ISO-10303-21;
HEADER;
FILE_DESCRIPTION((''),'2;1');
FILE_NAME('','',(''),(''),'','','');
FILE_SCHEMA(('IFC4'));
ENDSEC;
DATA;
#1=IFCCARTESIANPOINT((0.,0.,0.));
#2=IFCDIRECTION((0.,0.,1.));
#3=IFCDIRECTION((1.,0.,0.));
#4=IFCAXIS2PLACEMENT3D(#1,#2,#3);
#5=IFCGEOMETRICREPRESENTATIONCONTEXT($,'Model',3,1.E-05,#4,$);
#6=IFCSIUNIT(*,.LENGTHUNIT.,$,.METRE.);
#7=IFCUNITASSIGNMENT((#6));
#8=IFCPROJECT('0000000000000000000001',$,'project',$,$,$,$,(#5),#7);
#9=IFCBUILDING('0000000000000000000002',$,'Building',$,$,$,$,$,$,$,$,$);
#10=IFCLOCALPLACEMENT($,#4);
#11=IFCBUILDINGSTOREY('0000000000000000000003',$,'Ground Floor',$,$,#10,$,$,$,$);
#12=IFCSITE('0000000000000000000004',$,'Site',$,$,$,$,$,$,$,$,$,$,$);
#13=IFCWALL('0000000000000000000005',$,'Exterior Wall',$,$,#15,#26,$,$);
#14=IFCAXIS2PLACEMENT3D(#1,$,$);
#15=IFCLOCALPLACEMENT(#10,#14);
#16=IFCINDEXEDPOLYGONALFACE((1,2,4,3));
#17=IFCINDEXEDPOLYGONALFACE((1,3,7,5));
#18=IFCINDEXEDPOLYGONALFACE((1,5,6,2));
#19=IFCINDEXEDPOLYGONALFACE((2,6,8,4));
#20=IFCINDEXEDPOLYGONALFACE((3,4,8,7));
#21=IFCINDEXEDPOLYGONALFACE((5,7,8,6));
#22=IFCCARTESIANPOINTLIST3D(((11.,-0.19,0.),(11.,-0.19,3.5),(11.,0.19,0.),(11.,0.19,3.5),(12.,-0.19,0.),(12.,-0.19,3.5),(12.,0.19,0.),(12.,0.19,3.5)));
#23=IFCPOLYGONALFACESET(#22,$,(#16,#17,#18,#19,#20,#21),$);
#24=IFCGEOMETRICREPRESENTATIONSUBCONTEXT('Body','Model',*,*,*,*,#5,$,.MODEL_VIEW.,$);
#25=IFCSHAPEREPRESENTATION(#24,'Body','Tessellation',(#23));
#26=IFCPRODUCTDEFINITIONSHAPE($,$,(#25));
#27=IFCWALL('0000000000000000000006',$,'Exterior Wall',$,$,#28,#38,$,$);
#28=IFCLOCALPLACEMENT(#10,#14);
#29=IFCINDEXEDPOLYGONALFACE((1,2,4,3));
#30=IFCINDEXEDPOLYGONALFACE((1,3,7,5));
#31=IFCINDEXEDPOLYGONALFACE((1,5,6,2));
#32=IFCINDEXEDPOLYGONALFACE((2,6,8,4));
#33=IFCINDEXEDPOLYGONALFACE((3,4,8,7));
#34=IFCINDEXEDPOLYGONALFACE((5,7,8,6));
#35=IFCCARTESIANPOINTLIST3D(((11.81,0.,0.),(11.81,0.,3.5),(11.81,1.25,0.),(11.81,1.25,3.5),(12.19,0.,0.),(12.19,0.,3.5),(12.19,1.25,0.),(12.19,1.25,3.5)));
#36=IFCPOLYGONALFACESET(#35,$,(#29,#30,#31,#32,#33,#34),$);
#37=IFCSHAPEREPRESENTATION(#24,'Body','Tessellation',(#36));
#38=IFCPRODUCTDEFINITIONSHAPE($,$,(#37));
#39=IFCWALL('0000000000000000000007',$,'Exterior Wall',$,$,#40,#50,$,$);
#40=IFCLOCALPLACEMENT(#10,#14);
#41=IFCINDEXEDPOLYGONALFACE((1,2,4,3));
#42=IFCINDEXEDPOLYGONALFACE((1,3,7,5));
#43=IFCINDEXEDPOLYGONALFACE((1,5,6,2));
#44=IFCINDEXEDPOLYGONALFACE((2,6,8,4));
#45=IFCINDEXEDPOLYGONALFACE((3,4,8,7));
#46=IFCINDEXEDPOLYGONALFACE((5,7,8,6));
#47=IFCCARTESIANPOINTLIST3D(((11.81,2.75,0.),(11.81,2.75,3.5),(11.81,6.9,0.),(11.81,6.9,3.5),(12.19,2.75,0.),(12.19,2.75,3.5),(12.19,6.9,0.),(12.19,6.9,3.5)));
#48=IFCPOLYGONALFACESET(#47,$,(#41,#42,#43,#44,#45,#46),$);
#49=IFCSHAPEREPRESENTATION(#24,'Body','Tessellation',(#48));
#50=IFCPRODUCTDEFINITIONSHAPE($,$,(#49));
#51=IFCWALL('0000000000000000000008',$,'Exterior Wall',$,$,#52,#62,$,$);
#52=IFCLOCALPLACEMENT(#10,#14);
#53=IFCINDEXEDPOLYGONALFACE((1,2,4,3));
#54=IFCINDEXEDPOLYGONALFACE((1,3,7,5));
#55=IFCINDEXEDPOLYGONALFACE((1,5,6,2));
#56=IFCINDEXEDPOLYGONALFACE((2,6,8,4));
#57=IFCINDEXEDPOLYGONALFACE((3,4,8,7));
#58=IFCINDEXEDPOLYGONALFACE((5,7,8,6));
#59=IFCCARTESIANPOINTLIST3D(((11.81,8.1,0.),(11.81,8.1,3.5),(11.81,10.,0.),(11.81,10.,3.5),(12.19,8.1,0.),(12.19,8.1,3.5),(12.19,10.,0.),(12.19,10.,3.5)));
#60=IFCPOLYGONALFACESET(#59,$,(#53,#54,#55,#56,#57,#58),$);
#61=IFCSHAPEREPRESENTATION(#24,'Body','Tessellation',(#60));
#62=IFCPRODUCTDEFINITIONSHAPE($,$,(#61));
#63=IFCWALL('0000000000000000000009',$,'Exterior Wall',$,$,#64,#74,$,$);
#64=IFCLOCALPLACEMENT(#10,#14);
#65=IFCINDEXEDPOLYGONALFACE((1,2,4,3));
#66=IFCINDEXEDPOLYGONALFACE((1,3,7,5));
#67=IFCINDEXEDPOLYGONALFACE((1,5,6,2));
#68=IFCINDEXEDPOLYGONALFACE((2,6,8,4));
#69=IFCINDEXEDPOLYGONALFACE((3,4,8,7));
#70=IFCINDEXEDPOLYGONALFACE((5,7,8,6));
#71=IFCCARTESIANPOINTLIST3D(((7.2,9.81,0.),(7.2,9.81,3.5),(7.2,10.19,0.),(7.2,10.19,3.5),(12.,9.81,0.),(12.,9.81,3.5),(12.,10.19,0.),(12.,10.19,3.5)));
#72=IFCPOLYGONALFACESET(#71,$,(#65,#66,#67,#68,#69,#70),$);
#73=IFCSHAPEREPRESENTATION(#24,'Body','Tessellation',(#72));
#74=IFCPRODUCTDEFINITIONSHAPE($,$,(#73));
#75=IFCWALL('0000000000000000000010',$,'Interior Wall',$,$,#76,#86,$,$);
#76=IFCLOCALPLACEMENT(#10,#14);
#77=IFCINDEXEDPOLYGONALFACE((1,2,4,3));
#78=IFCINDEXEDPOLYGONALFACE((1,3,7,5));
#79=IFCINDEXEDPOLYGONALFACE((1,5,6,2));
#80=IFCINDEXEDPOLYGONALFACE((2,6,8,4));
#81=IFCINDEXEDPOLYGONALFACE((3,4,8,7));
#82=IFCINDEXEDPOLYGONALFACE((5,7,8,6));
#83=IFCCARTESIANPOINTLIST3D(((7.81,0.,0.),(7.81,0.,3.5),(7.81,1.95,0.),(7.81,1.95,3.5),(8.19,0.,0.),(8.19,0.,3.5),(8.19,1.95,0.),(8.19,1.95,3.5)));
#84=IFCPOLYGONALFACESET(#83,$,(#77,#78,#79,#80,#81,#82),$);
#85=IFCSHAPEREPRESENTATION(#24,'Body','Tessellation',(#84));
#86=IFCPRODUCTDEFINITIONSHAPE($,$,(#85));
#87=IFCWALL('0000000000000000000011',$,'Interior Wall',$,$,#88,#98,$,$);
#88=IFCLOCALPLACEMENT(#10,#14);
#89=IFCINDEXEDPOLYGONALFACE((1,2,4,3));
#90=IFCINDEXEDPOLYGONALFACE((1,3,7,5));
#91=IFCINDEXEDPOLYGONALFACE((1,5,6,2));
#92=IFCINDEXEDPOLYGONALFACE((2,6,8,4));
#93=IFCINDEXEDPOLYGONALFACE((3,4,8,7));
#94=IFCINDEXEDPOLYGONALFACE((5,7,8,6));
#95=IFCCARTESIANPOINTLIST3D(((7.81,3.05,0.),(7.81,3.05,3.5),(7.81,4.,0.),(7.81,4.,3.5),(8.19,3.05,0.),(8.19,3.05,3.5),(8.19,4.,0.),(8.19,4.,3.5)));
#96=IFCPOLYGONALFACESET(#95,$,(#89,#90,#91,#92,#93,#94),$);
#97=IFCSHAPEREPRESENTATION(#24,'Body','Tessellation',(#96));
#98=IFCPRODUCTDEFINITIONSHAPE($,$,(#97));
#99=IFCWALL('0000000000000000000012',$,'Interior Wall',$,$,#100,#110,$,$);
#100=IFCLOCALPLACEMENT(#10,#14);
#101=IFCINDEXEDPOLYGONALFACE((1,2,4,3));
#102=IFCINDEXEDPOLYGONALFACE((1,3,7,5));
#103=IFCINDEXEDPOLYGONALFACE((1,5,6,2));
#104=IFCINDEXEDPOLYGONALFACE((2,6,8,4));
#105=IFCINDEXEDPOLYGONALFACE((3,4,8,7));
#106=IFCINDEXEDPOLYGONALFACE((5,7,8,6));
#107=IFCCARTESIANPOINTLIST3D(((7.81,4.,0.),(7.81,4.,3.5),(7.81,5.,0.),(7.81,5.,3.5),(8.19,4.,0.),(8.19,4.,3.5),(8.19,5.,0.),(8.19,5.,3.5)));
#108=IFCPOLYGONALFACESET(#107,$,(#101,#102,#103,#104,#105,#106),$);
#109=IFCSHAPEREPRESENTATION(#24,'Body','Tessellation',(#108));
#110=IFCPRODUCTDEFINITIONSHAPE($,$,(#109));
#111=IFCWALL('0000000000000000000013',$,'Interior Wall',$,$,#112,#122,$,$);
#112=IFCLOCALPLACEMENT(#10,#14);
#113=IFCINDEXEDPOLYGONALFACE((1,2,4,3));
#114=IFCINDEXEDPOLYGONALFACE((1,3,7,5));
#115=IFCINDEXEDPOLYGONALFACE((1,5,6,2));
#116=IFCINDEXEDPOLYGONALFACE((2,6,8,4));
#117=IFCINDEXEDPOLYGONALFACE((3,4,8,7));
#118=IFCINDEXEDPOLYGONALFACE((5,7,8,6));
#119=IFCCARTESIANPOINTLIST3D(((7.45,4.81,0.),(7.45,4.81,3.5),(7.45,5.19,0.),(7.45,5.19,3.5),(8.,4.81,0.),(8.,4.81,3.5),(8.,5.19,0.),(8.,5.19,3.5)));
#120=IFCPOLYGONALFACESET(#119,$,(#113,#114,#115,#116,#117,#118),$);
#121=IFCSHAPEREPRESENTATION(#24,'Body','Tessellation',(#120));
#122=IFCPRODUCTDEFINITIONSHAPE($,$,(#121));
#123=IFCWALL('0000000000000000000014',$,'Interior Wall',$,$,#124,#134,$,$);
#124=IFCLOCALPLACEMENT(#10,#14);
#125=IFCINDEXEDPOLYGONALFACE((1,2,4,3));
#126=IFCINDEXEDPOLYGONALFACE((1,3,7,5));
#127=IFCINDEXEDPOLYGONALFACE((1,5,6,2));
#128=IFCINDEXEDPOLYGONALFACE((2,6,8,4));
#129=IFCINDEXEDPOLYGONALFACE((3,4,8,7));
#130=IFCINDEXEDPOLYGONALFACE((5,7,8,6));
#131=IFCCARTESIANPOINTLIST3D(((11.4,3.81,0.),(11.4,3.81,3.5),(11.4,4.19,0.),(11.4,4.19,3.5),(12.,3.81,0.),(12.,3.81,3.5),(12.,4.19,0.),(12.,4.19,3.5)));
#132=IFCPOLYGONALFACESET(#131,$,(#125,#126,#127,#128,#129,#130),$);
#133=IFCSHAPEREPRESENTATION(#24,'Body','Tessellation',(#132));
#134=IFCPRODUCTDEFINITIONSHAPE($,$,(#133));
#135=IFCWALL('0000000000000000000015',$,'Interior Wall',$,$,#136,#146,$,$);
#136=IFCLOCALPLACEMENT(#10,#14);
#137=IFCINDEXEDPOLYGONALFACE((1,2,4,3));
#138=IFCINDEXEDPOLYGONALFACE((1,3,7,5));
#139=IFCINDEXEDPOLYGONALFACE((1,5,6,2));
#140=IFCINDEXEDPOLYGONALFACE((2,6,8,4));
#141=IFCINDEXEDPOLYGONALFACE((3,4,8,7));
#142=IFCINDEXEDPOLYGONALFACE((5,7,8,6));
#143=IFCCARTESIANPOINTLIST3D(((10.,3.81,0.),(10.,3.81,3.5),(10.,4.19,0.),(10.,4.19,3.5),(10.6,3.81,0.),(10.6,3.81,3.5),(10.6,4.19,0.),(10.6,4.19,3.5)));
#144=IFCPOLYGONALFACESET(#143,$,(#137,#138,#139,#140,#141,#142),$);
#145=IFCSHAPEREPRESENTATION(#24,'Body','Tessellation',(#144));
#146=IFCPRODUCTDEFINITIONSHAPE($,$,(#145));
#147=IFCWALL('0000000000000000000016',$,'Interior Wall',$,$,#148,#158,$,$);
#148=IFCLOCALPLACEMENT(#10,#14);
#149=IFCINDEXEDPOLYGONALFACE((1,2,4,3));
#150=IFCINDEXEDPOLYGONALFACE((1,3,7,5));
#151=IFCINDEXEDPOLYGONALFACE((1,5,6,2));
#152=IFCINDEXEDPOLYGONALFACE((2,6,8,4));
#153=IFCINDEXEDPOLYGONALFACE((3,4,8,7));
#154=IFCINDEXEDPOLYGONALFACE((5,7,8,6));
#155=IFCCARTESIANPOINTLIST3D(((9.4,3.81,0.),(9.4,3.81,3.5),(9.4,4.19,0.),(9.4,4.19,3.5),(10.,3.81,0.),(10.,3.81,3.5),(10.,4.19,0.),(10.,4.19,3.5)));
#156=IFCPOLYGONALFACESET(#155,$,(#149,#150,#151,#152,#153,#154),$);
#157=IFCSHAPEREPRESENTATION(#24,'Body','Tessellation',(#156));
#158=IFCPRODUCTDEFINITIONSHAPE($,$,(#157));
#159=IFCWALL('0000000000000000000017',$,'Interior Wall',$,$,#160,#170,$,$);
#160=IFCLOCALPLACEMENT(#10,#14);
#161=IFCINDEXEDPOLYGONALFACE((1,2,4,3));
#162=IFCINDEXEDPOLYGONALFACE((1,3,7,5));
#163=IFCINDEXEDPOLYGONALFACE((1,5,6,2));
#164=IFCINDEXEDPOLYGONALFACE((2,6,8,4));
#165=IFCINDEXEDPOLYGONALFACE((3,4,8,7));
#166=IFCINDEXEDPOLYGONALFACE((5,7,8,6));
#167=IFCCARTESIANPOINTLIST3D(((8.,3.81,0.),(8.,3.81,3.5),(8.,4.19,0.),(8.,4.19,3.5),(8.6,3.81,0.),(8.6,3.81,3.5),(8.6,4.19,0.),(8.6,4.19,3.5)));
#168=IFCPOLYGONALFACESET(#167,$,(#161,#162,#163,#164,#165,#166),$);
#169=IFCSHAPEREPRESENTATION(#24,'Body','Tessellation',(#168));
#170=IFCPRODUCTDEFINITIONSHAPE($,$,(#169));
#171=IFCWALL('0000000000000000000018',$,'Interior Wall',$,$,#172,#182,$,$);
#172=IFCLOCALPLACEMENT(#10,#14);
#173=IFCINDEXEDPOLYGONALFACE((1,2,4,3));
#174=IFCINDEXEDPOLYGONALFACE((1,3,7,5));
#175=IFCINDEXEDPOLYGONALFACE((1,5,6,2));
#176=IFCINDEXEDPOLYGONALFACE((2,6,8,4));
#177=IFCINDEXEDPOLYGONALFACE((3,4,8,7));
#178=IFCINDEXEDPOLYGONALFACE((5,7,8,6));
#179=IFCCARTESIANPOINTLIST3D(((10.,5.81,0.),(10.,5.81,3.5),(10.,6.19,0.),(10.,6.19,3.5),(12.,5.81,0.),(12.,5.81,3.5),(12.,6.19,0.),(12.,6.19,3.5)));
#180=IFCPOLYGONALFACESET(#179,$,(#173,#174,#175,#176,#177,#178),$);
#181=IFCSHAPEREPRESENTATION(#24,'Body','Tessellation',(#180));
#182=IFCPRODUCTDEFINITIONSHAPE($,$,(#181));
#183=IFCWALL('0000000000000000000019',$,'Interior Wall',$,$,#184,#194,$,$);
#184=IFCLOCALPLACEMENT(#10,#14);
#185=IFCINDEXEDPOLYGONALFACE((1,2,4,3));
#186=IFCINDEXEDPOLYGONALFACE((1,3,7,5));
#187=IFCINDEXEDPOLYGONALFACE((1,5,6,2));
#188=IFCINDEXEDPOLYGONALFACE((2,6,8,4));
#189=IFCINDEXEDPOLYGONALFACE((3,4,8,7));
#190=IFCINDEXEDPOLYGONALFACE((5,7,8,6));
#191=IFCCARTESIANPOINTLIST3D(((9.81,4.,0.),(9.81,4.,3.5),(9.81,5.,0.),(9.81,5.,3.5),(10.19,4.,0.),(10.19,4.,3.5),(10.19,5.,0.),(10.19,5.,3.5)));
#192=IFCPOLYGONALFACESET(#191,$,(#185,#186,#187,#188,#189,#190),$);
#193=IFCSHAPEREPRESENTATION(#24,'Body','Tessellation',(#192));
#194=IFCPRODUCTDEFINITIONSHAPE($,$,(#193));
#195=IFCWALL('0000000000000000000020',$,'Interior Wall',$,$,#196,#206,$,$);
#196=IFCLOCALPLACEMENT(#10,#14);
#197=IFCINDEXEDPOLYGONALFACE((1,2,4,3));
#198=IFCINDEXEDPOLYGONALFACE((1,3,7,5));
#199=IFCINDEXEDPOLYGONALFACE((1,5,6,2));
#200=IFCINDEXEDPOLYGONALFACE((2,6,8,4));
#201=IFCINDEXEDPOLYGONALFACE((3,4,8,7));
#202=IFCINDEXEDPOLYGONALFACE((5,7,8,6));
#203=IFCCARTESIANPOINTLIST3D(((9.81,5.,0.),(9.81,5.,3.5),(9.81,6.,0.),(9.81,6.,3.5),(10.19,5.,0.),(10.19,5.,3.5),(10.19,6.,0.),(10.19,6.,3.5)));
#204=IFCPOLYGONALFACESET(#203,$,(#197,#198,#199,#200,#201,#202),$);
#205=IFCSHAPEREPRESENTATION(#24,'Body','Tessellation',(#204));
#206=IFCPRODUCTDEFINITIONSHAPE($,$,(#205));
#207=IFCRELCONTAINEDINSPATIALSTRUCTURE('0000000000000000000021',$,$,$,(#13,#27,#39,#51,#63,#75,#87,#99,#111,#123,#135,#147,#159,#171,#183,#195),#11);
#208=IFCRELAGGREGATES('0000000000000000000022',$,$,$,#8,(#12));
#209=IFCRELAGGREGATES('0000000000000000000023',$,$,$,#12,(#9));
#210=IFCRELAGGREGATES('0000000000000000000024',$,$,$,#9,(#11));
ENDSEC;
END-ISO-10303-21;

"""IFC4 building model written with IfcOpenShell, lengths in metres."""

from ifc_helpers import new_model, si_unit, frame, origin_with_axes, place, context, subcontext, project, spatial, indexed_curve, outline, extrude, element, save


model = new_model("IFC4")

# Units and contexts
model_context = context("Model", 3, precision=1e-05, world=origin_with_axes())
body_context = subcontext(model_context, "Body", "Model", "MODEL_VIEW")
ifc_project = project(units=[si_unit("LENGTHUNIT", "METRE")], contexts=[model_context])

# Site, building, storey
site = spatial("IfcSite", under=ifc_project, Name="Site")
building = spatial("IfcBuilding", under=site, Name="Building")
storey_placement = place(None, origin_with_axes())
storey = spatial("IfcBuildingStorey", under=building, at=storey_placement, Name="Ground Floor")

# Walls
wall_1_placement = place(storey_placement, frame((11.0, 0.0, 0.0), z_axis=(0.0, 0.0, 1.0), x_axis=(1.0, 0.0, 0.0)))
element("IfcWall", 1, at=wall_1_placement, inside=storey, Name="Exterior Wall", context=body_context, shape_type="SweptSolid", body=[
    extrude(outline(indexed_curve([(0.0, 0.0), (0.0, 0.38), (1.0, 0.38), (1.0, 0.0), (0.0, 0.0)], self_intersect=False)), frame((0.0, -0.19, 0.0), z_axis=(0.0, 0.0, 1.0), x_axis=(1.0, 0.0, 0.0)), (0.0, 0.0, 1.0), 3.5),
])
wall_2_placement = place(storey_placement, frame((12.0, 0.0, 0.0), z_axis=(0.0, 0.0, 1.0), x_axis=(0.0, 1.0, 0.0)))
element("IfcWall", 2, at=wall_2_placement, inside=storey, Name="Exterior Wall", context=body_context, shape_type="SweptSolid", body=[
    extrude(outline(indexed_curve([(0.0, 0.0), (0.0, 0.38), (1.25, 0.38), (1.25, 0.0), (0.0, 0.0)], self_intersect=False)), frame((0.0, -0.19, 0.0), z_axis=(0.0, 0.0, 1.0), x_axis=(1.0, 0.0, 0.0)), (0.0, 0.0, 1.0), 3.5),
])
wall_3_placement = place(storey_placement, frame((12.0, 2.75, 0.0), z_axis=(0.0, 0.0, 1.0), x_axis=(0.0, 1.0, 0.0)))
element("IfcWall", 3, at=wall_3_placement, inside=storey, Name="Exterior Wall", context=body_context, shape_type="SweptSolid", body=[
    extrude(outline(indexed_curve([(0.0, 0.0), (0.0, 0.38), (4.15, 0.38), (4.15, 0.0), (0.0, 0.0)], self_intersect=False)), frame((0.0, -0.19, 0.0), z_axis=(0.0, 0.0, 1.0), x_axis=(1.0, 0.0, 0.0)), (0.0, 0.0, 1.0), 3.5),
])
wall_4_placement = place(storey_placement, frame((12.0, 8.1, 0.0), z_axis=(0.0, 0.0, 1.0), x_axis=(0.0, 1.0, 0.0)))
element("IfcWall", 4, at=wall_4_placement, inside=storey, Name="Exterior Wall", context=body_context, shape_type="SweptSolid", body=[
    extrude(outline(indexed_curve([(0.0, 0.0), (0.0, 0.38), (1.9, 0.38), (1.9, 0.0), (0.0, 0.0)], self_intersect=False)), frame((0.0, -0.19, 0.0), z_axis=(0.0, 0.0, 1.0), x_axis=(1.0, 0.0, 0.0)), (0.0, 0.0, 1.0), 3.5),
])
wall_5_placement = place(storey_placement, frame((12.0, 10.0, 0.0), z_axis=(0.0, 0.0, 1.0), x_axis=(-1.0, 0.0, 0.0)))
element("IfcWall", 5, at=wall_5_placement, inside=storey, Name="Exterior Wall", context=body_context, shape_type="SweptSolid", body=[
    extrude(outline(indexed_curve([(0.0, 0.0), (0.0, 0.38), (4.8, 0.38), (4.8, 0.0), (0.0, 0.0)], self_intersect=False)), frame((0.0, -0.19, 0.0), z_axis=(0.0, 0.0, 1.0), x_axis=(1.0, 0.0, 0.0)), (0.0, 0.0, 1.0), 3.5),
])
wall_6_placement = place(storey_placement, frame((8.0, 0.0, 0.0), z_axis=(0.0, 0.0, 1.0), x_axis=(0.0, 1.0, 0.0)))
element("IfcWall", 6, at=wall_6_placement, inside=storey, Name="Interior Wall", context=body_context, shape_type="SweptSolid", body=[
    extrude(outline(indexed_curve([(0.0, 0.0), (0.0, 0.38), (1.95, 0.38), (1.95, 0.0), (0.0, 0.0)], self_intersect=False)), frame((0.0, -0.19, 0.0), z_axis=(0.0, 0.0, 1.0), x_axis=(1.0, 0.0, 0.0)), (0.0, 0.0, 1.0), 3.5),
])
wall_7_placement = place(storey_placement, frame((8.0, 3.05, 0.0), z_axis=(0.0, 0.0, 1.0), x_axis=(0.0, 1.0, 0.0)))
element("IfcWall", 7, at=wall_7_placement, inside=storey, Name="Interior Wall", context=body_context, shape_type="SweptSolid", body=[
    extrude(outline(indexed_curve([(0.0, 0.0), (0.0, 0.38), (0.95, 0.38), (0.95, 0.0), (0.0, 0.0)], self_intersect=False)), frame((0.0, -0.19, 0.0), z_axis=(0.0, 0.0, 1.0), x_axis=(1.0, 0.0, 0.0)), (0.0, 0.0, 1.0), 3.5),
])
wall_8_placement = place(storey_placement, frame((8.0, 4.0, 0.0), z_axis=(0.0, 0.0, 1.0), x_axis=(0.0, 1.0, 0.0)))
element("IfcWall", 8, at=wall_8_placement, inside=storey, Name="Interior Wall", context=body_context, shape_type="SweptSolid", body=[
    extrude(outline(indexed_curve([(0.0, 0.0), (0.0, 0.38), (1.0, 0.38), (1.0, 0.0), (0.0, 0.0)], self_intersect=False)), frame((0.0, -0.19, 0.0), z_axis=(0.0, 0.0, 1.0), x_axis=(1.0, 0.0, 0.0)), (0.0, 0.0, 1.0), 3.5),
])
wall_9_placement = place(storey_placement, frame((8.0, 5.0, 0.0), z_axis=(0.0, 0.0, 1.0), x_axis=(-1.0, 0.0, 0.0)))
element("IfcWall", 9, at=wall_9_placement, inside=storey, Name="Interior Wall", context=body_context, shape_type="SweptSolid", body=[
    extrude(outline(indexed_curve([(0.0, 0.0), (0.0, 0.38), (0.55, 0.38), (0.55, 0.0), (0.0, 0.0)], self_intersect=False)), frame((0.0, -0.19, 0.0), z_axis=(0.0, 0.0, 1.0), x_axis=(1.0, 0.0, 0.0)), (0.0, 0.0, 1.0), 3.5),
])
for number, where, z_axis, x_axis, name in (
    (10, (12.0, 4.0, 0.0), (0.0, 0.0, 1.0), (-1.0, 0.0, 0.0), "Interior Wall"),
    (11, (10.6, 4.0, 0.0), (0.0, 0.0, 1.0), (-1.0, 0.0, 0.0), "Interior Wall"),
    (12, (10.0, 4.0, 0.0), (0.0, 0.0, 1.0), (-1.0, 0.0, 0.0), "Interior Wall"),
    (13, (8.6, 4.0, 0.0), (0.0, 0.0, 1.0), (-1.0, 0.0, 0.0), "Interior Wall"),
):
    element("IfcWall", number, at=place(storey_placement, frame(where, z_axis=z_axis, x_axis=x_axis)), inside=storey, Name=name, context=body_context, shape_type="SweptSolid", body=[
        extrude(outline(indexed_curve([(0.0, 0.0), (0.0, 0.38), (0.6, 0.38), (0.6, 0.0), (0.0, 0.0)], self_intersect=False)), frame((0.0, -0.19, 0.0), z_axis=(0.0, 0.0, 1.0), x_axis=(1.0, 0.0, 0.0)), (0.0, 0.0, 1.0), 3.5),
    ])
wall_10_placement = place(storey_placement, frame((12.0, 6.0, 0.0), z_axis=(0.0, 0.0, 1.0), x_axis=(-1.0, 0.0, 0.0)))
element("IfcWall", 14, at=wall_10_placement, inside=storey, Name="Interior Wall", context=body_context, shape_type="SweptSolid", body=[
    extrude(outline(indexed_curve([(0.0, 0.0), (0.0, 0.38), (2.0, 0.38), (2.0, 0.0), (0.0, 0.0)], self_intersect=False)), frame((0.0, -0.19, 0.0), z_axis=(0.0, 0.0, 1.0), x_axis=(1.0, 0.0, 0.0)), (0.0, 0.0, 1.0), 3.5),
])
for number, where, z_axis, x_axis, name in (
    (15, (10.0, 5.0, 0.0), (0.0, 0.0, 1.0), (0.0, -1.0, 0.0), "Interior Wall"),
    (16, (10.0, 6.0, 0.0), (0.0, 0.0, 1.0), (0.0, -1.0, 0.0), "Interior Wall"),
):
    element("IfcWall", number, at=place(storey_placement, frame(where, z_axis=z_axis, x_axis=x_axis)), inside=storey, Name=name, context=body_context, shape_type="SweptSolid", body=[
        extrude(outline(indexed_curve([(0.0, 0.0), (0.0, 0.38), (1.0, 0.38), (1.0, 0.0), (0.0, 0.0)], self_intersect=False)), frame((0.0, -0.19, 0.0), z_axis=(0.0, 0.0, 1.0), x_axis=(1.0, 0.0, 0.0)), (0.0, 0.0, 1.0), 3.5),
    ])

save(model, "model.ifc")
